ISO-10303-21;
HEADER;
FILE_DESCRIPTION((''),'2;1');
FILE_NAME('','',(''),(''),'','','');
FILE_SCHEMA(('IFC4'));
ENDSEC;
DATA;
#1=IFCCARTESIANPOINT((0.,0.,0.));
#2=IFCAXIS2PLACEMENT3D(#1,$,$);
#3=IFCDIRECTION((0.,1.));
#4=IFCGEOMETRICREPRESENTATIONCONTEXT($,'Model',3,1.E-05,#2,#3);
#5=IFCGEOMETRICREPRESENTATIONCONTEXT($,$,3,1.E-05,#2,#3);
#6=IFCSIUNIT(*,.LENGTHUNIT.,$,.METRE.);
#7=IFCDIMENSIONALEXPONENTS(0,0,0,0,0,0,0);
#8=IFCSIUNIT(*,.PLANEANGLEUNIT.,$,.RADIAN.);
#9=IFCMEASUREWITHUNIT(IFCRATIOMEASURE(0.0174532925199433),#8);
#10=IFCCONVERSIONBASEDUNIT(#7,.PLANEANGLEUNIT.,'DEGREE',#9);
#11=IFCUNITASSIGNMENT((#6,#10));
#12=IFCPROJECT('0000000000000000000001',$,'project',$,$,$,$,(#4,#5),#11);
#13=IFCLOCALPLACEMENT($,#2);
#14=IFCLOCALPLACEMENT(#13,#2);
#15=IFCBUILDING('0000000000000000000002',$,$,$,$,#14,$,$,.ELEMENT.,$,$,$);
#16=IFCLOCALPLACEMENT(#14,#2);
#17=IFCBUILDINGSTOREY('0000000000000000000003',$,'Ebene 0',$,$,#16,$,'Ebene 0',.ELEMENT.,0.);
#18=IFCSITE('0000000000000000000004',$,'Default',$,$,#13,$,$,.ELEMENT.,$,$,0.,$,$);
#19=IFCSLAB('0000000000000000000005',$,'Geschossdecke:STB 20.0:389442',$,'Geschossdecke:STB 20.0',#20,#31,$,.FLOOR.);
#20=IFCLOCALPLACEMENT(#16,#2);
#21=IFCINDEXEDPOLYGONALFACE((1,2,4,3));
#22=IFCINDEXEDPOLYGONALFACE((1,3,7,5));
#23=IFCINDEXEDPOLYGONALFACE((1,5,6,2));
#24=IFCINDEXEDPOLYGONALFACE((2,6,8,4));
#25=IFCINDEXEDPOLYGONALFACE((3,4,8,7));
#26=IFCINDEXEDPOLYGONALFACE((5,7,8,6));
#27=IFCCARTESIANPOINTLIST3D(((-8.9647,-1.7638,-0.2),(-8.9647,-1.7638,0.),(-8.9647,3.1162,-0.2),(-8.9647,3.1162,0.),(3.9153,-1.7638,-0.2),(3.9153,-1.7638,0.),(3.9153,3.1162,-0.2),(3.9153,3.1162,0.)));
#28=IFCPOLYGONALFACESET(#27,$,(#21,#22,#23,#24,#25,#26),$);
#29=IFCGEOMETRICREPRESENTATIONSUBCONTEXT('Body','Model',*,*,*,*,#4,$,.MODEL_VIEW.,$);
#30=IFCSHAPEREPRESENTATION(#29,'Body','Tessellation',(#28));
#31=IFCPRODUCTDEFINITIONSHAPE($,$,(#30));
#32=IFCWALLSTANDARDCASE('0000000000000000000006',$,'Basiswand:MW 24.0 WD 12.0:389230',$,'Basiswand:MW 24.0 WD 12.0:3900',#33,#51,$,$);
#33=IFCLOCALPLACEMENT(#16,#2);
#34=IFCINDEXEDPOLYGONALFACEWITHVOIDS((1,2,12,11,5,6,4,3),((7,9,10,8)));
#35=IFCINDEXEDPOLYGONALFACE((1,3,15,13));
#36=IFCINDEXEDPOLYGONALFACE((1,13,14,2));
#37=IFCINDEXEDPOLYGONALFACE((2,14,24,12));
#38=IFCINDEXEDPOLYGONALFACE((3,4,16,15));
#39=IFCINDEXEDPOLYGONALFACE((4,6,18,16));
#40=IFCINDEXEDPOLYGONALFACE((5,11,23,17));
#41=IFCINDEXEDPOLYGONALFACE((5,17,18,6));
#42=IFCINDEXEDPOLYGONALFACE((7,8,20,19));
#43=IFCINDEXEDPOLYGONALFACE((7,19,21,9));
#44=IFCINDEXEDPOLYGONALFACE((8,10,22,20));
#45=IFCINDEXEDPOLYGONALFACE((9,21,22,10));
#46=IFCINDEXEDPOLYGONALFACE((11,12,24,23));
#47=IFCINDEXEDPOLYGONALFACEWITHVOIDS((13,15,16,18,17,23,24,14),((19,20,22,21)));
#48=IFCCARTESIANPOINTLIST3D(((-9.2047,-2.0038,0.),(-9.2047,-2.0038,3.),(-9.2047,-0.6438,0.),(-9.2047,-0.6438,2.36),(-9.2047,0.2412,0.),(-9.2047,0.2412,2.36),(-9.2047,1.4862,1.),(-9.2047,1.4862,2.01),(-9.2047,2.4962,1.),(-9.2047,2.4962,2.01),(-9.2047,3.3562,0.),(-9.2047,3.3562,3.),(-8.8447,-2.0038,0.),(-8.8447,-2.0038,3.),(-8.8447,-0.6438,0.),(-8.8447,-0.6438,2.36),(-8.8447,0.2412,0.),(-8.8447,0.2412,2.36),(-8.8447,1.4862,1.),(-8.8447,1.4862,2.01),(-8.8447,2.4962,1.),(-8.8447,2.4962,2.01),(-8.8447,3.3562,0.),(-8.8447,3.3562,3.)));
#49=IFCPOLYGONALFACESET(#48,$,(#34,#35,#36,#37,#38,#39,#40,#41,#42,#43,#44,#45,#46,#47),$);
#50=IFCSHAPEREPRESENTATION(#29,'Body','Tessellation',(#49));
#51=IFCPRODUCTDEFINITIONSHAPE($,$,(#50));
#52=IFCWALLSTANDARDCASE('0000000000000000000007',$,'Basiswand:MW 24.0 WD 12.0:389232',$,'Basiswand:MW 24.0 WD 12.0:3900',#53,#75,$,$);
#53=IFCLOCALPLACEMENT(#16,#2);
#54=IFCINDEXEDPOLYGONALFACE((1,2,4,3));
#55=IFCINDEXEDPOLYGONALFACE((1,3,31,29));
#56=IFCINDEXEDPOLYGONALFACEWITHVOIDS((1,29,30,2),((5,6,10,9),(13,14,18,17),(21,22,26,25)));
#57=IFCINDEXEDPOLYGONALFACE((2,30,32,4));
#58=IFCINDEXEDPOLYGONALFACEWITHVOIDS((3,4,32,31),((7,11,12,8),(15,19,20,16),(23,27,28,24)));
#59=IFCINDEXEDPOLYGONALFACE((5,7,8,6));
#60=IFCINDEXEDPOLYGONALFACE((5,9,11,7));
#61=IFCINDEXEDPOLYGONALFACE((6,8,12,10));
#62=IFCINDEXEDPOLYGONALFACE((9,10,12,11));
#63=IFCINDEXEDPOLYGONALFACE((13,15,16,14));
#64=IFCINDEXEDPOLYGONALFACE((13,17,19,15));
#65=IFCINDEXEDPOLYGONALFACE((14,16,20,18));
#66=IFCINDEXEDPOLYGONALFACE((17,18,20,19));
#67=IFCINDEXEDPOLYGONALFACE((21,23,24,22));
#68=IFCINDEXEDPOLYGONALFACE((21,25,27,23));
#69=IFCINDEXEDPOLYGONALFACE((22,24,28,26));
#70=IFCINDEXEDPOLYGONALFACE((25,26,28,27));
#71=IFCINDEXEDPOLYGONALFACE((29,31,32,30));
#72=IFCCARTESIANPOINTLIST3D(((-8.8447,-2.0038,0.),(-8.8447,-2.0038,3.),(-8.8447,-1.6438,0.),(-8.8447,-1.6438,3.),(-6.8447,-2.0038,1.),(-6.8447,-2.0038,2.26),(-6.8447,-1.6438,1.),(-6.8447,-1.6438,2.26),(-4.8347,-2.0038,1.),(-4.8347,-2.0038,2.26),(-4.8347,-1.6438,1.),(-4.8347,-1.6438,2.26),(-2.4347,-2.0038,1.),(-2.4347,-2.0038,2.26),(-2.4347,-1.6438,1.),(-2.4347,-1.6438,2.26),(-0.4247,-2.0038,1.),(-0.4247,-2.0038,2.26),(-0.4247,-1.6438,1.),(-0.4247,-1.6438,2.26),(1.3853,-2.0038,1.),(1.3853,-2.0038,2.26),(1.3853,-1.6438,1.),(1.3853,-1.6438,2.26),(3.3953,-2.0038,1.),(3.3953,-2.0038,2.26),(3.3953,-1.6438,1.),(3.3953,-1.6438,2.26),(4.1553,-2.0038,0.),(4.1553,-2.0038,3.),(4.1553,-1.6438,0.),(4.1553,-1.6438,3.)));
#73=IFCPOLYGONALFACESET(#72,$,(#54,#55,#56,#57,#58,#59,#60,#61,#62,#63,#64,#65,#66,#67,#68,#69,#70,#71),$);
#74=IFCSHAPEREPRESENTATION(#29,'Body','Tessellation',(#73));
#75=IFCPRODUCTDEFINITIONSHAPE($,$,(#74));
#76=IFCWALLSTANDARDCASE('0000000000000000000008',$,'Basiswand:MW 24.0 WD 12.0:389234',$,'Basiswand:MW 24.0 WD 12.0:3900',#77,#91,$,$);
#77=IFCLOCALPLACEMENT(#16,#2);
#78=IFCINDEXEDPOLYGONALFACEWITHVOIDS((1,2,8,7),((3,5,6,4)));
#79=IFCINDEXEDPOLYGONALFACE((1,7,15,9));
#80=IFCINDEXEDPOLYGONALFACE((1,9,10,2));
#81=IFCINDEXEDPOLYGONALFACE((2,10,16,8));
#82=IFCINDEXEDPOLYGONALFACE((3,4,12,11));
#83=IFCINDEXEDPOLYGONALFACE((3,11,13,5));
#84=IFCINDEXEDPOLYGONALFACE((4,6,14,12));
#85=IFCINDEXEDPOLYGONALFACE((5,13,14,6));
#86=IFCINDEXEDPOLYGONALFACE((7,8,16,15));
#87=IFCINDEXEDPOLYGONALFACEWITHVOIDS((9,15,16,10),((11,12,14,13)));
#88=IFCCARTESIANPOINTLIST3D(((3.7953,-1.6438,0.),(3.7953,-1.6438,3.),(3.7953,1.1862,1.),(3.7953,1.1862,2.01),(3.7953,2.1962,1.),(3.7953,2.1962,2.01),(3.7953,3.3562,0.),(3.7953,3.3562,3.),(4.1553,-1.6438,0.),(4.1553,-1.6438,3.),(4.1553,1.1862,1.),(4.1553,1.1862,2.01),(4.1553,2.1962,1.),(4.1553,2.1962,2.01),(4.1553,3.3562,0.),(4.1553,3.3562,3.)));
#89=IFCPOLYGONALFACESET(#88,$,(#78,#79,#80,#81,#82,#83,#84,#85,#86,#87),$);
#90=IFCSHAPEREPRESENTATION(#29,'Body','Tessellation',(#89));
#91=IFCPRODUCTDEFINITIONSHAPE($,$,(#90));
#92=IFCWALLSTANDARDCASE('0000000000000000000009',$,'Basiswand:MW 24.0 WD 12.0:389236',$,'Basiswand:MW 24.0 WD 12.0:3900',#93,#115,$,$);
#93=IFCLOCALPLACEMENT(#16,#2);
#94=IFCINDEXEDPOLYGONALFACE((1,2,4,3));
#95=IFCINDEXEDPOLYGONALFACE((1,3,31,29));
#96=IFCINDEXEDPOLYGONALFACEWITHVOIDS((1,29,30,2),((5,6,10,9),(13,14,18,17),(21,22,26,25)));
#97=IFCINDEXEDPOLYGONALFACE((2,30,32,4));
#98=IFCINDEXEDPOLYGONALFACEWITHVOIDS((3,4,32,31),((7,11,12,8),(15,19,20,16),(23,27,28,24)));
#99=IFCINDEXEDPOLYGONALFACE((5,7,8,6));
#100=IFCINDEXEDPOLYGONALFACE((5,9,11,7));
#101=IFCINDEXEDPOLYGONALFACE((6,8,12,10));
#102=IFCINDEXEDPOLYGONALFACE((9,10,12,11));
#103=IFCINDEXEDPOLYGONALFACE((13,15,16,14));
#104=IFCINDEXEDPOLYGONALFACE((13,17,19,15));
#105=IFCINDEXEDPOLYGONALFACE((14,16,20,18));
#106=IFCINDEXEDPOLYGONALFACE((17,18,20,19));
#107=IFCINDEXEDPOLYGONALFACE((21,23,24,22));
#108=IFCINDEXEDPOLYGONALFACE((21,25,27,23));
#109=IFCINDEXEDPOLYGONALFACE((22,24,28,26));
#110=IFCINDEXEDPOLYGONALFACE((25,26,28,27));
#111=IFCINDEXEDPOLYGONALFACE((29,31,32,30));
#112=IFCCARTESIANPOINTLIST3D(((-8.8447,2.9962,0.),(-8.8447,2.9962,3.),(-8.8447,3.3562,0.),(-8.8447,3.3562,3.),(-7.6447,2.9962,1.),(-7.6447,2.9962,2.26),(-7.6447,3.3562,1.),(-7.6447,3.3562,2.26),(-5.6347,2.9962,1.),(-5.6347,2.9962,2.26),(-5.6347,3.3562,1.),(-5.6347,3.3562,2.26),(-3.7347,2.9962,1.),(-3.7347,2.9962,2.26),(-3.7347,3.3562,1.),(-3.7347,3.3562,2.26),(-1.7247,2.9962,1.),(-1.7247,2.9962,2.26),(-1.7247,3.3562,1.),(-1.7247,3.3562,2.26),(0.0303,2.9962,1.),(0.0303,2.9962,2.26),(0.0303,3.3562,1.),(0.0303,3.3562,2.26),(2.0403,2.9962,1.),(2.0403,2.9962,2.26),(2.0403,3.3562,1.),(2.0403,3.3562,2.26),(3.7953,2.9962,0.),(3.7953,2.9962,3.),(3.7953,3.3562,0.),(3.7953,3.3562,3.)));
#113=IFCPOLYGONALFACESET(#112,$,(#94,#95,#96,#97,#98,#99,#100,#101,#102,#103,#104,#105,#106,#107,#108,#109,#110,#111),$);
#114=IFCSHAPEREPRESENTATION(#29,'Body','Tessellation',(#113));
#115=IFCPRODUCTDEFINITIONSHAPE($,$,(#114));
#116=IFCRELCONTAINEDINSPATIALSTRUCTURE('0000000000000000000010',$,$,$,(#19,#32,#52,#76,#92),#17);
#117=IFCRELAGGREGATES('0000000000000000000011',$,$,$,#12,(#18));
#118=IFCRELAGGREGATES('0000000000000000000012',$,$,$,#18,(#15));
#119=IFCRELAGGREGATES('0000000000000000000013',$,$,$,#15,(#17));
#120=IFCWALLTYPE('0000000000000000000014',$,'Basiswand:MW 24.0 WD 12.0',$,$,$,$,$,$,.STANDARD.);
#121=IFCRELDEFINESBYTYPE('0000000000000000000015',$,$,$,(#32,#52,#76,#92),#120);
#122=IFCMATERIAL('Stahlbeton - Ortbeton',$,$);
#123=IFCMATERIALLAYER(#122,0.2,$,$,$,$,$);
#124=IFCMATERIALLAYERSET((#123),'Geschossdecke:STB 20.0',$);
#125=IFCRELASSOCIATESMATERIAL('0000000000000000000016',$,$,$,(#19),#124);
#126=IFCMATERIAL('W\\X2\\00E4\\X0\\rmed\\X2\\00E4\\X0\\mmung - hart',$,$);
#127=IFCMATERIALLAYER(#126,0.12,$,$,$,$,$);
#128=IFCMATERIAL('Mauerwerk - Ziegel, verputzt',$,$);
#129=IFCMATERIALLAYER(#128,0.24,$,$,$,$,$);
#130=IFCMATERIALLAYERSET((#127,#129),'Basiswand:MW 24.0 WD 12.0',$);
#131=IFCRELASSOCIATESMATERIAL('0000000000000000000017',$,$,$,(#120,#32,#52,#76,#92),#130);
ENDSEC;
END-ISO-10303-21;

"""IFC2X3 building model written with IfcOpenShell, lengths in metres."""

from ifc_helpers import new_model, entity, si_unit, converted_unit, direction, frame, frame_2d, origin, place, context, subcontext, project, spatial, rectangle, extrude, material, layer, layer_set, layer_usage, type_object, element, save


model = new_model("IFC2X3")

# Units and contexts
model_context = context("Model", 3, precision=1e-05, world=origin(), true_north=direction((0.0, 1.0)))
context_of_model = context(None, 3, precision=1e-05, world=origin(), true_north=direction((0.0, 1.0)))
body_context = subcontext(model_context, "Body", "Model", "MODEL_VIEW")
ifc_project = project(units=[si_unit("LENGTHUNIT", "METRE"), converted_unit("PLANEANGLEUNIT", "DEGREE", entity("IfcRatioMeasure", 0.0174532925199433), si_unit("PLANEANGLEUNIT", "RADIAN"), dimensions=[0, 0, 0, 0, 0, 0, 0])], contexts=[model_context, context_of_model])

# Site, building, storey
site_placement = place(None, origin())
site = spatial("IfcSite", under=ifc_project, at=site_placement, Name="Default", CompositionType="ELEMENT", RefElevation=0.0)
building_placement = place(site_placement, origin())
building = spatial("IfcBuilding", under=site, at=building_placement, CompositionType="ELEMENT")
storey_placement = place(building_placement, origin())
storey = spatial("IfcBuildingStorey", under=building, at=storey_placement, Name="Ebene 0", LongName="Ebene 0", CompositionType="ELEMENT", Elevation=0.0)

# Slab
ifc_material_1 = material(Name="Stahlbeton - Ortbeton")
ifc_layer_1 = layer(ifc_material_1, 0.2)
ifc_layer_set_1 = layer_set([ifc_layer_1], Name="Geschossdecke:STB 20.0")
ifc_layer_usage_1 = layer_usage(ifc_layer_set_1, "AXIS3", "POSITIVE", 0.0)
slab_placement = place(storey_placement, origin())
element("IfcSlab", 1, at=slab_placement, inside=storey, material=ifc_layer_usage_1, Name="Geschossdecke:STB 20.0:389442", ObjectType="Geschossdecke:STB 20.0", PredefinedType="FLOOR", context=body_context, shape_type="SweptSolid", body=[
    extrude(rectangle(XDim=4.88, YDim=12.88, at=frame_2d((0.0, 0.0), x_axis=(1.0, 0.0))), frame((-2.5247, 0.6762, 0.0), z_axis=(0.0, 0.0, -1.0), x_axis=(0.0, 1.0, 0.0)), (0.0, 0.0, 1.0), 0.2),
])

# Walls, openings
ifc_material_2 = material(Name="W\\X2\\00E4\\X0\\rmed\\X2\\00E4\\X0\\mmung - hart")
ifc_layer_2 = layer(ifc_material_2, 0.12)
ifc_material_3 = material(Name="Mauerwerk - Ziegel, verputzt")
ifc_layer_3 = layer(ifc_material_3, 0.24)
ifc_layer_set_2 = layer_set([ifc_layer_2, ifc_layer_3], Name="Basiswand:MW 24.0 WD 12.0")
ifc_layer_usage_2 = layer_usage(ifc_layer_set_2, "AXIS2", "NEGATIVE", 0.18)
wall_type = type_object("IfcWallType", Name="Basiswand:MW 24.0 WD 12.0", PredefinedType="STANDARD", material=ifc_layer_set_2)
wall_1_placement = place(storey_placement, frame((-9.0247, 3.3562, 0.0), z_axis=(0.0, 0.0, 1.0), x_axis=(0.0, -1.0, 0.0)))
wall_1 = element("IfcWallStandardCase", 2, at=wall_1_placement, inside=storey, type_object=wall_type, material=ifc_layer_usage_2, Name="Basiswand:MW 24.0 WD 12.0:389230", ObjectType="Basiswand:MW 24.0 WD 12.0:3900", context=body_context, shape_type="SweptSolid", body=[
    extrude(rectangle(XDim=5.36, YDim=0.36, at=frame_2d((2.68, 0.0), x_axis=(-1.0, 0.0))), origin(), (0.0, 0.0, 1.0), 3.0),
])
opening_1_placement = place(wall_1_placement, frame((4.0, 0.18, 0.0)))
element("IfcOpeningElement", 3, at=opening_1_placement, cuts=wall_1, ObjectType="Opening", context=body_context, shape_type="SweptSolid", body=[
    extrude(rectangle(XDim=2.36, YDim=0.885, at=frame_2d((1.18, 0.4425), x_axis=(1.0, 0.0))), frame((0.0, 0.0, 0.0), z_axis=(0.0, -1.0, 0.0), x_axis=(0.0, 0.0, 1.0)), (0.0, 0.0, 1.0), 0.36),
])
opening_2_placement = place(wall_1_placement, frame((1.87, 0.18, 1.0)))
element("IfcOpeningElement", 4, at=opening_2_placement, cuts=wall_1, ObjectType="Opening", context=body_context, shape_type="SweptSolid", body=[
    extrude(rectangle(XDim=1.01, YDim=1.01, at=frame_2d((0.505, 0.505), x_axis=(1.0, 0.0))), frame((0.0, 0.0, 0.0), z_axis=(0.0, -1.0, 0.0), x_axis=(0.0, 0.0, 1.0)), (0.0, 0.0, 1.0), 0.36),
])
wall_2_placement = place(storey_placement, frame((-8.8447, -1.8238, 0.0)))
wall_2 = element("IfcWallStandardCase", 5, at=wall_2_placement, inside=storey, type_object=wall_type, material=ifc_layer_usage_2, Name="Basiswand:MW 24.0 WD 12.0:389232", ObjectType="Basiswand:MW 24.0 WD 12.0:3900", context=body_context, shape_type="SweptSolid", body=[
    extrude(rectangle(XDim=13.0, YDim=0.36, at=frame_2d((6.5, 0.0), x_axis=(-1.0, 0.0))), origin(), (0.0, 0.0, 1.0), 3.0),
])
opening_3_placement = place(wall_2_placement, frame((4.01, 0.18, 1.0)))
element("IfcOpeningElement", 6, at=opening_3_placement, cuts=wall_2, ObjectType="Opening", context=body_context, shape_type="SweptSolid", body=[
    extrude(rectangle(XDim=1.26, YDim=2.01, at=frame_2d((0.63, 1.005), x_axis=(1.0, 0.0))), frame((0.0, 0.0, 0.0), z_axis=(0.0, -1.0, 0.0), x_axis=(0.0, 0.0, 1.0)), (0.0, 0.0, 1.0), 0.36),
])
opening_4_placement = place(wall_2_placement, frame((8.42, 0.18, 1.0)))
element("IfcOpeningElement", 7, at=opening_4_placement, cuts=wall_2, ObjectType="Opening", context=body_context, shape_type="SweptSolid", body=[
    extrude(rectangle(XDim=1.26, YDim=2.01, at=frame_2d((0.63, 1.005), x_axis=(1.0, 0.0))), frame((0.0, 0.0, 0.0), z_axis=(0.0, -1.0, 0.0), x_axis=(0.0, 0.0, 1.0)), (0.0, 0.0, 1.0), 0.36),
])
opening_5_placement = place(wall_2_placement, frame((12.24, 0.18, 1.0)))
element("IfcOpeningElement", 8, at=opening_5_placement, cuts=wall_2, ObjectType="Opening", context=body_context, shape_type="SweptSolid", body=[
    extrude(rectangle(XDim=1.26, YDim=2.01, at=frame_2d((0.63, 1.005), x_axis=(1.0, 0.0))), frame((0.0, 0.0, 0.0), z_axis=(0.0, -1.0, 0.0), x_axis=(0.0, 0.0, 1.0)), (0.0, 0.0, 1.0), 0.36),
])

# Wall, opening
wall_3_placement = place(storey_placement, frame((3.9753, -1.6438, 0.0), z_axis=(0.0, 0.0, 1.0), x_axis=(0.0, 1.0, 0.0)))
wall_3 = element("IfcWallStandardCase", 9, at=wall_3_placement, inside=storey, type_object=wall_type, material=ifc_layer_usage_2, Name="Basiswand:MW 24.0 WD 12.0:389234", ObjectType="Basiswand:MW 24.0 WD 12.0:3900", context=body_context, shape_type="SweptSolid", body=[
    extrude(rectangle(XDim=5.0, YDim=0.36, at=frame_2d((2.5, 0.0), x_axis=(-1.0, 0.0))), origin(), (0.0, 0.0, 1.0), 3.0),
])
opening_6_placement = place(wall_3_placement, frame((3.84, 0.18, 1.0)))
element("IfcOpeningElement", 10, at=opening_6_placement, cuts=wall_3, ObjectType="Opening", context=body_context, shape_type="SweptSolid", body=[
    extrude(rectangle(XDim=1.01, YDim=1.01, at=frame_2d((0.505, 0.505), x_axis=(1.0, 0.0))), frame((0.0, 0.0, 0.0), z_axis=(0.0, -1.0, 0.0), x_axis=(0.0, 0.0, 1.0)), (0.0, 0.0, 1.0), 0.36),
])

# Wall, openings
wall_4_placement = place(storey_placement, frame((3.7953, 3.1762, 0.0), z_axis=(0.0, 0.0, 1.0), x_axis=(-1.0, 0.0, 0.0)))
wall_4 = element("IfcWallStandardCase", 11, at=wall_4_placement, inside=storey, type_object=wall_type, material=ifc_layer_usage_2, Name="Basiswand:MW 24.0 WD 12.0:389236", ObjectType="Basiswand:MW 24.0 WD 12.0:3900", context=body_context, shape_type="SweptSolid", body=[
    extrude(rectangle(XDim=12.64, YDim=0.36, at=frame_2d((6.32, 0.0), x_axis=(-1.0, 0.0))), origin(), (0.0, 0.0, 1.0), 3.0),
])
opening_7_placement = place(wall_4_placement, frame((11.44, 0.18, 1.0)))
element("IfcOpeningElement", 12, at=opening_7_placement, cuts=wall_4, ObjectType="Opening", context=body_context, shape_type="SweptSolid", body=[
    extrude(rectangle(XDim=1.26, YDim=2.01, at=frame_2d((0.63, 1.005), x_axis=(1.0, 0.0))), frame((0.0, 0.0, 0.0), z_axis=(0.0, -1.0, 0.0), x_axis=(0.0, 0.0, 1.0)), (0.0, 0.0, 1.0), 0.36),
])
opening_8_placement = place(wall_4_placement, frame((7.53, 0.18, 1.0)))
element("IfcOpeningElement", 13, at=opening_8_placement, cuts=wall_4, ObjectType="Opening", context=body_context, shape_type="SweptSolid", body=[
    extrude(rectangle(XDim=1.26, YDim=2.01, at=frame_2d((0.63, 1.005), x_axis=(1.0, 0.0))), frame((0.0, 0.0, 0.0), z_axis=(0.0, -1.0, 0.0), x_axis=(0.0, 0.0, 1.0)), (0.0, 0.0, 1.0), 0.36),
])
opening_9_placement = place(wall_4_placement, frame((3.765, 0.18, 1.0)))
element("IfcOpeningElement", 14, at=opening_9_placement, cuts=wall_4, ObjectType="Opening", context=body_context, shape_type="SweptSolid", body=[
    extrude(rectangle(XDim=1.26, YDim=2.01, at=frame_2d((0.63, 1.005), x_axis=(1.0, 0.0))), frame((0.0, 0.0, 0.0), z_axis=(0.0, -1.0, 0.0), x_axis=(0.0, 0.0, 1.0)), (0.0, 0.0, 1.0), 0.36),
])

save(model, "model.ifc")
